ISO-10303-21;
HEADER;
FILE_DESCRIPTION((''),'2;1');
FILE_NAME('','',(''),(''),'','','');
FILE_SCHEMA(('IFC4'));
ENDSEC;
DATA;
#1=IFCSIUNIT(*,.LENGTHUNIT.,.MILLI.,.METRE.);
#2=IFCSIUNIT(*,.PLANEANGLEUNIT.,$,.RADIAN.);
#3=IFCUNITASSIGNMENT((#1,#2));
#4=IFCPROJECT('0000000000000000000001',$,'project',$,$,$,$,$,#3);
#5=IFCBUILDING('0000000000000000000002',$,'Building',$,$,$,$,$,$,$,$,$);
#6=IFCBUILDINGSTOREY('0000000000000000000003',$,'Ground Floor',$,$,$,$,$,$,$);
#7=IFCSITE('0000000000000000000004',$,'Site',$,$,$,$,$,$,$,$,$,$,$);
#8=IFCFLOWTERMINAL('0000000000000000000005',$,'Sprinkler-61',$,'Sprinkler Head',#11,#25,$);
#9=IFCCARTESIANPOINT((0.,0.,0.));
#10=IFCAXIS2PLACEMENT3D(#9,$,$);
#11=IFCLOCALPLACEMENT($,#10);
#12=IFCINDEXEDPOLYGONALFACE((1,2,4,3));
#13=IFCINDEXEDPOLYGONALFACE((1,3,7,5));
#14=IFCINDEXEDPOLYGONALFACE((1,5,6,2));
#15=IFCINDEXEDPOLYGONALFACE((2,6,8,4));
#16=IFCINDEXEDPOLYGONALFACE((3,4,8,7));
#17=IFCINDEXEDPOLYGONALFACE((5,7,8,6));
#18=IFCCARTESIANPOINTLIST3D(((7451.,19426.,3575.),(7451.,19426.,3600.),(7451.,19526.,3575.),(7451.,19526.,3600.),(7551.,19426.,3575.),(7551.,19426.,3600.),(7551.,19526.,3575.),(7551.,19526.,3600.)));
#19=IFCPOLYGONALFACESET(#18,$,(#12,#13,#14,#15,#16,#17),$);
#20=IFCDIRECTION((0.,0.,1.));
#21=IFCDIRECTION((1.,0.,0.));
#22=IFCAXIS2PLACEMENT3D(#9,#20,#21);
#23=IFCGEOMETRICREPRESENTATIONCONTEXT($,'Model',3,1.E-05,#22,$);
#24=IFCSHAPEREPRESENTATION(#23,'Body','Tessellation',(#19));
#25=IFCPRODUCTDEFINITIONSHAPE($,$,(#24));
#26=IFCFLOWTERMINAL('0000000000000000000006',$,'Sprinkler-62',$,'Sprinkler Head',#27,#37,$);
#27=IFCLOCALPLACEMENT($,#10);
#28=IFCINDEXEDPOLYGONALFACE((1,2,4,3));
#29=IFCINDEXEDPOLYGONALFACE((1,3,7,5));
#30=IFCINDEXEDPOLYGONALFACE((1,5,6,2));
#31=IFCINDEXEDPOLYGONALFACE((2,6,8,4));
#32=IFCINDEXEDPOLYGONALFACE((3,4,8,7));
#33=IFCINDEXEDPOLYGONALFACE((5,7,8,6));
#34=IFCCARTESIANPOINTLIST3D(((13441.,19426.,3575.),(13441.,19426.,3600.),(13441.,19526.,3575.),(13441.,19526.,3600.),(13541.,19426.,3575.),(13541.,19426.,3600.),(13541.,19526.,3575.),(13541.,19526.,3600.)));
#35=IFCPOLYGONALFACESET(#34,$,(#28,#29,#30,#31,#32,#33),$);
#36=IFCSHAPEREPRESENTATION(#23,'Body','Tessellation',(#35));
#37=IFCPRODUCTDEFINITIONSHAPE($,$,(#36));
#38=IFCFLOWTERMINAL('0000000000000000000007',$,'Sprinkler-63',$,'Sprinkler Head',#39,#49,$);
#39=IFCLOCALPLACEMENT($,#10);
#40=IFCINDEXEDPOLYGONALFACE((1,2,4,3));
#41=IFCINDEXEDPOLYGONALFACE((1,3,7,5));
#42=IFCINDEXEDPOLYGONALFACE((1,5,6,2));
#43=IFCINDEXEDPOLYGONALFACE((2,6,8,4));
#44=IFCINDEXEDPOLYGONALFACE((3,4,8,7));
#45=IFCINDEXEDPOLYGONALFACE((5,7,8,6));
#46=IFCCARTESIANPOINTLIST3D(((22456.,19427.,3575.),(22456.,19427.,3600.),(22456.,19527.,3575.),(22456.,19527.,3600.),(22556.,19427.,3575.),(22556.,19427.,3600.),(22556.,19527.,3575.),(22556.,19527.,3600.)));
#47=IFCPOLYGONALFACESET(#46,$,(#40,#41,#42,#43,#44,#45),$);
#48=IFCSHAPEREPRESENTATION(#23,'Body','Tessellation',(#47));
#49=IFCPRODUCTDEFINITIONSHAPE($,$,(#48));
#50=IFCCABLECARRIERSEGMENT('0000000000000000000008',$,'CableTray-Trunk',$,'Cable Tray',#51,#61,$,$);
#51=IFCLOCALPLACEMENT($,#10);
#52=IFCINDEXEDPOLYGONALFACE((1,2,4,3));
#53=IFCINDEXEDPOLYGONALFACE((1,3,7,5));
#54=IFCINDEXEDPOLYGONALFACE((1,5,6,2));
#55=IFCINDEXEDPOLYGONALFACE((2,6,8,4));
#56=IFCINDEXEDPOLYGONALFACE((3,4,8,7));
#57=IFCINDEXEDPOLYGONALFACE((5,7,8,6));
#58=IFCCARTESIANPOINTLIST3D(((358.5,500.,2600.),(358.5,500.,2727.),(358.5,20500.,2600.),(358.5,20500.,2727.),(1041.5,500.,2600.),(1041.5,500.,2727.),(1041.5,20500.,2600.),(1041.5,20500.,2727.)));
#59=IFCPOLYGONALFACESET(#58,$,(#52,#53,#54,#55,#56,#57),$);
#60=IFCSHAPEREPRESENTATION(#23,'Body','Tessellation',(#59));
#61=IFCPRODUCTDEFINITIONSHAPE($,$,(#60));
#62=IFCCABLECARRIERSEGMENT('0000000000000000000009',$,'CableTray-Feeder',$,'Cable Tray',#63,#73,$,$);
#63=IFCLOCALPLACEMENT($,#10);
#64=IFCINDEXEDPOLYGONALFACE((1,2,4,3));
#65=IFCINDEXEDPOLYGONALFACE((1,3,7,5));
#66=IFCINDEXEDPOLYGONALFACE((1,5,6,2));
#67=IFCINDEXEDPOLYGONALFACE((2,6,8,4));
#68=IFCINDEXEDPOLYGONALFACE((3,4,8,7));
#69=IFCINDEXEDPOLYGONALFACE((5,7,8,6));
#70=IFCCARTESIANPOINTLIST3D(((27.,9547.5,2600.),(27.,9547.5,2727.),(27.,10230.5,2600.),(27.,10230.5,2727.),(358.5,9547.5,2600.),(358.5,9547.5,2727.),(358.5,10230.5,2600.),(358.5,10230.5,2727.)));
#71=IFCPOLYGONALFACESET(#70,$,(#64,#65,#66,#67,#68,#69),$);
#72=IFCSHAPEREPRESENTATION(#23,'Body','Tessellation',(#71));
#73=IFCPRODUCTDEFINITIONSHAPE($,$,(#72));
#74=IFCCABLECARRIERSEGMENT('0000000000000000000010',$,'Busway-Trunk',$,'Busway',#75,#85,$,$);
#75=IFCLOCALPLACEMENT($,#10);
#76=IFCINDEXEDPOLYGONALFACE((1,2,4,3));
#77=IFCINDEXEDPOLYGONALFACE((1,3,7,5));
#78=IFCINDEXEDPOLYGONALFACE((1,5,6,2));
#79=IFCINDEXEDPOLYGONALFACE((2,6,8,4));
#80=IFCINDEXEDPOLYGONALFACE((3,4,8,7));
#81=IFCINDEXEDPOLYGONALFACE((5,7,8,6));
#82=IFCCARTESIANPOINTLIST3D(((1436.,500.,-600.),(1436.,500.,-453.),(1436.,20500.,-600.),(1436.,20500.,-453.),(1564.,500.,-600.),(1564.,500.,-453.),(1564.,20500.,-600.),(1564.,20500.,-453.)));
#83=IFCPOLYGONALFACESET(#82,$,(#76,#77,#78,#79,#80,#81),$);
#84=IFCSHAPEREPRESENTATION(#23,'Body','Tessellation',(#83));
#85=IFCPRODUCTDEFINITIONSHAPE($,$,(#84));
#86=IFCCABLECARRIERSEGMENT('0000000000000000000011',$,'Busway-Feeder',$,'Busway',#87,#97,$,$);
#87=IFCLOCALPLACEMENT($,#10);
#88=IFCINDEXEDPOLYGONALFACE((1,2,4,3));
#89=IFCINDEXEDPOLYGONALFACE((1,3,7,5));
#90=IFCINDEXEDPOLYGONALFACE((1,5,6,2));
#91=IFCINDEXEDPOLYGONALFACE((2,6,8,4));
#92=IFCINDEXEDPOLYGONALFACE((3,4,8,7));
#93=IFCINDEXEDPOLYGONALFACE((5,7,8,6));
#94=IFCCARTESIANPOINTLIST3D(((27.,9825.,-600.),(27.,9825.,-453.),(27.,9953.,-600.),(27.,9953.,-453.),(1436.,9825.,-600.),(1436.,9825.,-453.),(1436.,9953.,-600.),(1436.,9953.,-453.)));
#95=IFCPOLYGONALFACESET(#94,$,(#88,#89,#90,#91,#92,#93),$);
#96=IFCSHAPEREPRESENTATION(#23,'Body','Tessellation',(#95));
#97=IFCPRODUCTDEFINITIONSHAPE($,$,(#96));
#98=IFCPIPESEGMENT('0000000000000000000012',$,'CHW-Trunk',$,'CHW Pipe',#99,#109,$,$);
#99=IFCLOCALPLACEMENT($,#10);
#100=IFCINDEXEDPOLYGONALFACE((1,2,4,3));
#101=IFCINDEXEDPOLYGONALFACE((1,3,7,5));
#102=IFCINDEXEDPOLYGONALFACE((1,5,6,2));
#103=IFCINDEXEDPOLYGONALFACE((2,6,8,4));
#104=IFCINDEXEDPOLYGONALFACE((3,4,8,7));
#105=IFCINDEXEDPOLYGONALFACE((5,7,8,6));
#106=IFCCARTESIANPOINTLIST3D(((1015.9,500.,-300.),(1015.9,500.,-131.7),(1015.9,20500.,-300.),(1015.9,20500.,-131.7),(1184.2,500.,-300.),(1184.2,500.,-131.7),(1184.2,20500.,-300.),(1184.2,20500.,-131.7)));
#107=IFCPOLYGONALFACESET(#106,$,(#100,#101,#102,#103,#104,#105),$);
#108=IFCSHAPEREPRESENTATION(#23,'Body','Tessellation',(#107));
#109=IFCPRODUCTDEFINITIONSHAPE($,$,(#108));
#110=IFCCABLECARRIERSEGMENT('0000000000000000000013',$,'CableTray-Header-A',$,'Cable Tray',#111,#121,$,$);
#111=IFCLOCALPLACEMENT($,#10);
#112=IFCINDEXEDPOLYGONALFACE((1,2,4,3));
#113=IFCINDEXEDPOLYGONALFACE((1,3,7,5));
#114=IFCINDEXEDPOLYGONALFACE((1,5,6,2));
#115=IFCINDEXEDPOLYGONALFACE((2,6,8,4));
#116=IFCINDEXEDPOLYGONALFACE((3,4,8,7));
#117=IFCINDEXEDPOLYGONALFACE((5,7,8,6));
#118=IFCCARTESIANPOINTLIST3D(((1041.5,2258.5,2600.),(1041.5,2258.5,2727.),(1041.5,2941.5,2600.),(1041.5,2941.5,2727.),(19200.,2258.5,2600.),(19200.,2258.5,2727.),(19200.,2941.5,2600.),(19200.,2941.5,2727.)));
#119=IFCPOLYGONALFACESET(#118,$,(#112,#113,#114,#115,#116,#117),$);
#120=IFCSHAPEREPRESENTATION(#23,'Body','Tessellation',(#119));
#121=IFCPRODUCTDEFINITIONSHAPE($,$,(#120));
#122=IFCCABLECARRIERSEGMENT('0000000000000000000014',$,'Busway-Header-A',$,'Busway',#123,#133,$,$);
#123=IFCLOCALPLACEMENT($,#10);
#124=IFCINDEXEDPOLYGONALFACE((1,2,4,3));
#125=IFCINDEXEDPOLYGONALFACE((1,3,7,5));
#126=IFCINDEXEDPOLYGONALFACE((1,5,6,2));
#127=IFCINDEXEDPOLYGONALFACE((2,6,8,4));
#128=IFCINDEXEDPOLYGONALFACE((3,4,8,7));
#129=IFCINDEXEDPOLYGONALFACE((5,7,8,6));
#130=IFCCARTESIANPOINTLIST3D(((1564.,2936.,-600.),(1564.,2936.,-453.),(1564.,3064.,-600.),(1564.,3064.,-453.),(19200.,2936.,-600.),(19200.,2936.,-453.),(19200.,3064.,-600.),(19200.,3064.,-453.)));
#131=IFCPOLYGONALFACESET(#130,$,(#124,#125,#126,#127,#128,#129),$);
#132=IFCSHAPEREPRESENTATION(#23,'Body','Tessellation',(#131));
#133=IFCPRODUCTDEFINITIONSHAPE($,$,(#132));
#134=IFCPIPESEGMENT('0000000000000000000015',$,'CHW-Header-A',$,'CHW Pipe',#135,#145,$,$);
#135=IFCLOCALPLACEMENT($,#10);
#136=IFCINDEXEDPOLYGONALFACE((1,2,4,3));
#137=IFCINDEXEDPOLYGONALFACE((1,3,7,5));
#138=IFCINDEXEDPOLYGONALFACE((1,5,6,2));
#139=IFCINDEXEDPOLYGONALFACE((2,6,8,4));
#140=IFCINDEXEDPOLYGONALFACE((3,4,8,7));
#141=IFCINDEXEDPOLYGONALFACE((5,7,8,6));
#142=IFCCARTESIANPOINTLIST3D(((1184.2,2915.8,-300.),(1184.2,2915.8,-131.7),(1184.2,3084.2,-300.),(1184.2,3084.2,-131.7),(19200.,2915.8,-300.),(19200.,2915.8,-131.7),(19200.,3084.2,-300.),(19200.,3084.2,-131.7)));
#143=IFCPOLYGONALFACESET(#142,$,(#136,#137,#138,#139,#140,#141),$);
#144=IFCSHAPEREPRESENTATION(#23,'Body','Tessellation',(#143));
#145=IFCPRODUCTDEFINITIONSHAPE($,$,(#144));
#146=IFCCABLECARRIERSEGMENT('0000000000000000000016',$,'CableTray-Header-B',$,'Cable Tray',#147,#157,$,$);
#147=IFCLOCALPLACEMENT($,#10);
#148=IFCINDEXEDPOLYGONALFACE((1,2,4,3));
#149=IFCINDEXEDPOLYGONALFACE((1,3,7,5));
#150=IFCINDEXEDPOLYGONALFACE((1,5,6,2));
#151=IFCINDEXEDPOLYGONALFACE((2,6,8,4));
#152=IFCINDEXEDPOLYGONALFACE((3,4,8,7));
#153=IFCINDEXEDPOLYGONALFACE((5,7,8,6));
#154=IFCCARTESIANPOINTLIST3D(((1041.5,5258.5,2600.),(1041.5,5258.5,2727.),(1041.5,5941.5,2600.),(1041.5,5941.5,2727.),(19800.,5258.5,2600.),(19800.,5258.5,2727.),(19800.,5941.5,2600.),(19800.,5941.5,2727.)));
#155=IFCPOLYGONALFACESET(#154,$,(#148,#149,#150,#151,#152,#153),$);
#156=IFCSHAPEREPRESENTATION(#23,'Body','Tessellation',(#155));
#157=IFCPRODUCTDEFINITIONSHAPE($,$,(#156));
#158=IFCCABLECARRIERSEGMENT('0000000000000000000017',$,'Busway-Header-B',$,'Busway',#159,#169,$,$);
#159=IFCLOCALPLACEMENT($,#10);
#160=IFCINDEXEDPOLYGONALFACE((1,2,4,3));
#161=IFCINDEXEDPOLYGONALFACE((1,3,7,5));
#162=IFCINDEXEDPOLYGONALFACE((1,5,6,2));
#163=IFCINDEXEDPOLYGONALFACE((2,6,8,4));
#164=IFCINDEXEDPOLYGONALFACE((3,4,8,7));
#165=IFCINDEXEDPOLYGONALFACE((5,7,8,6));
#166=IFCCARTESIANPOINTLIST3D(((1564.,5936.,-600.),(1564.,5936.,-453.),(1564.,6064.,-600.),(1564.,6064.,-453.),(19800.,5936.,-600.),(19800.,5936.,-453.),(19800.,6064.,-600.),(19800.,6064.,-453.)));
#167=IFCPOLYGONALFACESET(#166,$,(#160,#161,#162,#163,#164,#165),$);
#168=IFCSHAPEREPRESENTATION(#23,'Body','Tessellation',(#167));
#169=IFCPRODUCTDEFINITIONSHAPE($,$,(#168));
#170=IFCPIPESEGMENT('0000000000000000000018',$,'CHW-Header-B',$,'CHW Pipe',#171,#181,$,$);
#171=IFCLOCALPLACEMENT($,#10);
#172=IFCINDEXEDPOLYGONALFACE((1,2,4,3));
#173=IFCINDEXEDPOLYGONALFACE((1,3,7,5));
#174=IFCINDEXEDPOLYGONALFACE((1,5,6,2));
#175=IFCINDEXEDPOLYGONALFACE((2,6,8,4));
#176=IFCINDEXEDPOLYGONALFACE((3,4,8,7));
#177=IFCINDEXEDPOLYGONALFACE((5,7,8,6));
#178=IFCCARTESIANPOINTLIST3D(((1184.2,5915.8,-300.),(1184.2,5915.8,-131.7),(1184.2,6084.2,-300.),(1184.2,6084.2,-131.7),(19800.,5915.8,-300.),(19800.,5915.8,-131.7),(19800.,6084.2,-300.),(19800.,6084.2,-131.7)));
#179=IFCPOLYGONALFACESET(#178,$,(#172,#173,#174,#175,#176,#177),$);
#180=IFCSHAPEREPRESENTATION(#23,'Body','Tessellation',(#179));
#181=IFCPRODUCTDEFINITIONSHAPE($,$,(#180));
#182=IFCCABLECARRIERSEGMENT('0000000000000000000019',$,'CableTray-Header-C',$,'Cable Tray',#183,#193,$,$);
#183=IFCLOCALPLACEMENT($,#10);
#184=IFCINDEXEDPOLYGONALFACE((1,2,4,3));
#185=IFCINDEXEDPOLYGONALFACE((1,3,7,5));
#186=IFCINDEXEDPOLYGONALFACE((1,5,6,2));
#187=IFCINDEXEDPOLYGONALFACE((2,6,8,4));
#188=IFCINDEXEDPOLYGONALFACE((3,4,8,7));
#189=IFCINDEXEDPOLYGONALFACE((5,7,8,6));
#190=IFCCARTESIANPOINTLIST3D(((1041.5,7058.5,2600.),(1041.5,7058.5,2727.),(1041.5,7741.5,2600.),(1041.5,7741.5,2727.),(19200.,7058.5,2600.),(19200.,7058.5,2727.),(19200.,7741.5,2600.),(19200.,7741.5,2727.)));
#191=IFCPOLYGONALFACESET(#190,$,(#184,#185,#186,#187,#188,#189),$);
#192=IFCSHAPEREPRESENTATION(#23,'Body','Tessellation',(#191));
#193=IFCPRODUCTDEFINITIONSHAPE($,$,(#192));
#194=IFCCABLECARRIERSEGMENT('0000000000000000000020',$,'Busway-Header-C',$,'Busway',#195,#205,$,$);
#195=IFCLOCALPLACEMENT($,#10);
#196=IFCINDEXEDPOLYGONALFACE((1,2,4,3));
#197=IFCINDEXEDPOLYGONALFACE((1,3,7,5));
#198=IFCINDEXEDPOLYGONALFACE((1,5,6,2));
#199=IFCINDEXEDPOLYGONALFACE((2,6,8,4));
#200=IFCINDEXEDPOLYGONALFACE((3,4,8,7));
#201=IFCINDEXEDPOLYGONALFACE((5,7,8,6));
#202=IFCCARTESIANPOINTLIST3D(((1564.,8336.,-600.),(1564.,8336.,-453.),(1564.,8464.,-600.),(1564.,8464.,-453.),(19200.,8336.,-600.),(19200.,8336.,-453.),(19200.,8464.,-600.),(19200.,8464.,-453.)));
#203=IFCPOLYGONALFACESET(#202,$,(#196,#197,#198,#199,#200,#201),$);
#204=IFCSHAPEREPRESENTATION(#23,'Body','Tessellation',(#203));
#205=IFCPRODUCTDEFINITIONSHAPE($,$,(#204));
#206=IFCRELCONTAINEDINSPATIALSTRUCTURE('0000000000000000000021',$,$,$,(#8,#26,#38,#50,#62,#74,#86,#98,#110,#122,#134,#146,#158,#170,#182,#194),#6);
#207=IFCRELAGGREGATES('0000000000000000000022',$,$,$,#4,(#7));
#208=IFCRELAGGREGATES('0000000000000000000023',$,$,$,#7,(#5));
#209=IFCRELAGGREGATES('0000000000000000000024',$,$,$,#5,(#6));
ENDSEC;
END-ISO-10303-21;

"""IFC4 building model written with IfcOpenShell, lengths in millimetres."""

from ifc_helpers import new_model, si_unit, frame, origin_with_axes, place, context, project, spatial, rectangle, extrude, element, save


model = new_model("IFC4")

# Units and contexts
model_context = context("Model", 3, precision=1e-05, world=origin_with_axes())
ifc_project = project(units=[si_unit("LENGTHUNIT", "METRE", prefix="MILLI"), si_unit("PLANEANGLEUNIT", "RADIAN")])

# Site, building, storey
site = spatial("IfcSite", under=ifc_project, Name="Site")
building = spatial("IfcBuilding", under=site, Name="Building")
storey = spatial("IfcBuildingStorey", under=building, Name="Ground Floor")

# Flow terminals
flow_terminal_1_placement = place(None, origin_with_axes())
element("IfcFlowTerminal", 1, at=flow_terminal_1_placement, inside=storey, Name="Sprinkler-61", ObjectType="Sprinkler Head", context=model_context, shape_type="SweptSolid", body=[
    extrude(rectangle(XDim=100.0, YDim=100.0), frame((7501.0, 19476.0, 3575.0), z_axis=(0.0, 0.0, 1.0), x_axis=(1.0, 0.0, 0.0)), (0.0, 0.0, 1.0), 25.0),
])
flow_terminal_2_placement = place(None, origin_with_axes())
element("IfcFlowTerminal", 2, at=flow_terminal_2_placement, inside=storey, Name="Sprinkler-62", ObjectType="Sprinkler Head", context=model_context, shape_type="SweptSolid", body=[
    extrude(rectangle(XDim=100.0, YDim=100.0), frame((13491.0, 19476.0, 3575.0), z_axis=(0.0, 0.0, 1.0), x_axis=(1.0, 0.0, 0.0)), (0.0, 0.0, 1.0), 25.0),
])
flow_terminal_3_placement = place(None, origin_with_axes())
element("IfcFlowTerminal", 3, at=flow_terminal_3_placement, inside=storey, Name="Sprinkler-63", ObjectType="Sprinkler Head", context=model_context, shape_type="SweptSolid", body=[
    extrude(rectangle(XDim=100.0, YDim=100.0), frame((22506.0, 19477.0, 3575.0), z_axis=(0.0, 0.0, 1.0), x_axis=(1.0, 0.0, 0.0)), (0.0, 0.0, 1.0), 25.0),
])

# Cable carrier segments
cable_carrier_segment_1_placement = place(None, origin_with_axes())
element("IfcCableCarrierSegment", 4, at=cable_carrier_segment_1_placement, inside=storey, Name="CableTray-Trunk", ObjectType="Cable Tray", context=model_context, shape_type="SweptSolid", body=[
    extrude(rectangle(XDim=683.0, YDim=20000.0), frame((700.0, 10500.0, 2600.0), z_axis=(0.0, 0.0, 1.0), x_axis=(1.0, 0.0, 0.0)), (0.0, 0.0, 1.0), 127.0),
])
cable_carrier_segment_2_placement = place(None, origin_with_axes())
element("IfcCableCarrierSegment", 5, at=cable_carrier_segment_2_placement, inside=storey, Name="CableTray-Feeder", ObjectType="Cable Tray", context=model_context, shape_type="SweptSolid", body=[
    extrude(rectangle(XDim=331.5, YDim=683.0), frame((192.8, 9889.0, 2600.0), z_axis=(0.0, 0.0, 1.0), x_axis=(1.0, 0.0, 0.0)), (0.0, 0.0, 1.0), 127.0),
])
cable_carrier_segment_3_placement = place(None, origin_with_axes())
element("IfcCableCarrierSegment", 6, at=cable_carrier_segment_3_placement, inside=storey, Name="Busway-Trunk", ObjectType="Busway", context=model_context, shape_type="SweptSolid", body=[
    extrude(rectangle(XDim=128.0, YDim=20000.0), frame((1500.0, 10500.0, -600.0), z_axis=(0.0, 0.0, 1.0), x_axis=(1.0, 0.0, 0.0)), (0.0, 0.0, 1.0), 147.0),
])
cable_carrier_segment_4_placement = place(None, origin_with_axes())
element("IfcCableCarrierSegment", 7, at=cable_carrier_segment_4_placement, inside=storey, Name="Busway-Feeder", ObjectType="Busway", context=model_context, shape_type="SweptSolid", body=[
    extrude(rectangle(XDim=1409.0, YDim=128.0), frame((731.5, 9889.0, -600.0), z_axis=(0.0, 0.0, 1.0), x_axis=(1.0, 0.0, 0.0)), (0.0, 0.0, 1.0), 147.0),
])

# Pipe segment
pipe_segment_1_placement = place(None, origin_with_axes())
element("IfcPipeSegment", 8, at=pipe_segment_1_placement, inside=storey, Name="CHW-Trunk", ObjectType="CHW Pipe", context=model_context, shape_type="SweptSolid", body=[
    extrude(rectangle(XDim=168.3, YDim=20000.0), frame((1100.0, 10500.0, -300.0), z_axis=(0.0, 0.0, 1.0), x_axis=(1.0, 0.0, 0.0)), (0.0, 0.0, 1.0), 168.3),
])

# Cable carrier segments
cable_carrier_segment_5_placement = place(None, origin_with_axes())
element("IfcCableCarrierSegment", 9, at=cable_carrier_segment_5_placement, inside=storey, Name="CableTray-Header-A", ObjectType="Cable Tray", context=model_context, shape_type="SweptSolid", body=[
    extrude(rectangle(XDim=18158.5, YDim=683.0), frame((10120.8, 2600.0, 2600.0), z_axis=(0.0, 0.0, 1.0), x_axis=(1.0, 0.0, 0.0)), (0.0, 0.0, 1.0), 127.0),
])
cable_carrier_segment_6_placement = place(None, origin_with_axes())
element("IfcCableCarrierSegment", 10, at=cable_carrier_segment_6_placement, inside=storey, Name="Busway-Header-A", ObjectType="Busway", context=model_context, shape_type="SweptSolid", body=[
    extrude(rectangle(XDim=17636.0, YDim=128.0), frame((10382.0, 3000.0, -600.0), z_axis=(0.0, 0.0, 1.0), x_axis=(1.0, 0.0, 0.0)), (0.0, 0.0, 1.0), 147.0),
])

# Pipe segment
pipe_segment_2_placement = place(None, origin_with_axes())
element("IfcPipeSegment", 11, at=pipe_segment_2_placement, inside=storey, Name="CHW-Header-A", ObjectType="CHW Pipe", context=model_context, shape_type="SweptSolid", body=[
    extrude(rectangle(XDim=18015.8, YDim=168.3), frame((10192.1, 3000.0, -300.0), z_axis=(0.0, 0.0, 1.0), x_axis=(1.0, 0.0, 0.0)), (0.0, 0.0, 1.0), 168.3),
])

# Cable carrier segments
cable_carrier_segment_7_placement = place(None, origin_with_axes())
element("IfcCableCarrierSegment", 12, at=cable_carrier_segment_7_placement, inside=storey, Name="CableTray-Header-B", ObjectType="Cable Tray", context=model_context, shape_type="SweptSolid", body=[
    extrude(rectangle(XDim=18758.5, YDim=683.0), frame((10420.8, 5600.0, 2600.0), z_axis=(0.0, 0.0, 1.0), x_axis=(1.0, 0.0, 0.0)), (0.0, 0.0, 1.0), 127.0),
])
cable_carrier_segment_8_placement = place(None, origin_with_axes())
element("IfcCableCarrierSegment", 13, at=cable_carrier_segment_8_placement, inside=storey, Name="Busway-Header-B", ObjectType="Busway", context=model_context, shape_type="SweptSolid", body=[
    extrude(rectangle(XDim=18236.0, YDim=128.0), frame((10682.0, 6000.0, -600.0), z_axis=(0.0, 0.0, 1.0), x_axis=(1.0, 0.0, 0.0)), (0.0, 0.0, 1.0), 147.0),
])

# Pipe segment
pipe_segment_3_placement = place(None, origin_with_axes())
element("IfcPipeSegment", 14, at=pipe_segment_3_placement, inside=storey, Name="CHW-Header-B", ObjectType="CHW Pipe", context=model_context, shape_type="SweptSolid", body=[
    extrude(rectangle(XDim=18615.8, YDim=168.3), frame((10492.1, 6000.0, -300.0), z_axis=(0.0, 0.0, 1.0), x_axis=(1.0, 0.0, 0.0)), (0.0, 0.0, 1.0), 168.3),
])

# Cable carrier segments
cable_carrier_segment_9_placement = place(None, origin_with_axes())
element("IfcCableCarrierSegment", 15, at=cable_carrier_segment_9_placement, inside=storey, Name="CableTray-Header-C", ObjectType="Cable Tray", context=model_context, shape_type="SweptSolid", body=[
    extrude(rectangle(XDim=18158.5, YDim=683.0), frame((10120.8, 7400.0, 2600.0), z_axis=(0.0, 0.0, 1.0), x_axis=(1.0, 0.0, 0.0)), (0.0, 0.0, 1.0), 127.0),
])
cable_carrier_segment_10_placement = place(None, origin_with_axes())
element("IfcCableCarrierSegment", 16, at=cable_carrier_segment_10_placement, inside=storey, Name="Busway-Header-C", ObjectType="Busway", context=model_context, shape_type="SweptSolid", body=[
    extrude(rectangle(XDim=17636.0, YDim=128.0), frame((10382.0, 8400.0, -600.0), z_axis=(0.0, 0.0, 1.0), x_axis=(1.0, 0.0, 0.0)), (0.0, 0.0, 1.0), 147.0),
])

save(model, "model.ifc")
